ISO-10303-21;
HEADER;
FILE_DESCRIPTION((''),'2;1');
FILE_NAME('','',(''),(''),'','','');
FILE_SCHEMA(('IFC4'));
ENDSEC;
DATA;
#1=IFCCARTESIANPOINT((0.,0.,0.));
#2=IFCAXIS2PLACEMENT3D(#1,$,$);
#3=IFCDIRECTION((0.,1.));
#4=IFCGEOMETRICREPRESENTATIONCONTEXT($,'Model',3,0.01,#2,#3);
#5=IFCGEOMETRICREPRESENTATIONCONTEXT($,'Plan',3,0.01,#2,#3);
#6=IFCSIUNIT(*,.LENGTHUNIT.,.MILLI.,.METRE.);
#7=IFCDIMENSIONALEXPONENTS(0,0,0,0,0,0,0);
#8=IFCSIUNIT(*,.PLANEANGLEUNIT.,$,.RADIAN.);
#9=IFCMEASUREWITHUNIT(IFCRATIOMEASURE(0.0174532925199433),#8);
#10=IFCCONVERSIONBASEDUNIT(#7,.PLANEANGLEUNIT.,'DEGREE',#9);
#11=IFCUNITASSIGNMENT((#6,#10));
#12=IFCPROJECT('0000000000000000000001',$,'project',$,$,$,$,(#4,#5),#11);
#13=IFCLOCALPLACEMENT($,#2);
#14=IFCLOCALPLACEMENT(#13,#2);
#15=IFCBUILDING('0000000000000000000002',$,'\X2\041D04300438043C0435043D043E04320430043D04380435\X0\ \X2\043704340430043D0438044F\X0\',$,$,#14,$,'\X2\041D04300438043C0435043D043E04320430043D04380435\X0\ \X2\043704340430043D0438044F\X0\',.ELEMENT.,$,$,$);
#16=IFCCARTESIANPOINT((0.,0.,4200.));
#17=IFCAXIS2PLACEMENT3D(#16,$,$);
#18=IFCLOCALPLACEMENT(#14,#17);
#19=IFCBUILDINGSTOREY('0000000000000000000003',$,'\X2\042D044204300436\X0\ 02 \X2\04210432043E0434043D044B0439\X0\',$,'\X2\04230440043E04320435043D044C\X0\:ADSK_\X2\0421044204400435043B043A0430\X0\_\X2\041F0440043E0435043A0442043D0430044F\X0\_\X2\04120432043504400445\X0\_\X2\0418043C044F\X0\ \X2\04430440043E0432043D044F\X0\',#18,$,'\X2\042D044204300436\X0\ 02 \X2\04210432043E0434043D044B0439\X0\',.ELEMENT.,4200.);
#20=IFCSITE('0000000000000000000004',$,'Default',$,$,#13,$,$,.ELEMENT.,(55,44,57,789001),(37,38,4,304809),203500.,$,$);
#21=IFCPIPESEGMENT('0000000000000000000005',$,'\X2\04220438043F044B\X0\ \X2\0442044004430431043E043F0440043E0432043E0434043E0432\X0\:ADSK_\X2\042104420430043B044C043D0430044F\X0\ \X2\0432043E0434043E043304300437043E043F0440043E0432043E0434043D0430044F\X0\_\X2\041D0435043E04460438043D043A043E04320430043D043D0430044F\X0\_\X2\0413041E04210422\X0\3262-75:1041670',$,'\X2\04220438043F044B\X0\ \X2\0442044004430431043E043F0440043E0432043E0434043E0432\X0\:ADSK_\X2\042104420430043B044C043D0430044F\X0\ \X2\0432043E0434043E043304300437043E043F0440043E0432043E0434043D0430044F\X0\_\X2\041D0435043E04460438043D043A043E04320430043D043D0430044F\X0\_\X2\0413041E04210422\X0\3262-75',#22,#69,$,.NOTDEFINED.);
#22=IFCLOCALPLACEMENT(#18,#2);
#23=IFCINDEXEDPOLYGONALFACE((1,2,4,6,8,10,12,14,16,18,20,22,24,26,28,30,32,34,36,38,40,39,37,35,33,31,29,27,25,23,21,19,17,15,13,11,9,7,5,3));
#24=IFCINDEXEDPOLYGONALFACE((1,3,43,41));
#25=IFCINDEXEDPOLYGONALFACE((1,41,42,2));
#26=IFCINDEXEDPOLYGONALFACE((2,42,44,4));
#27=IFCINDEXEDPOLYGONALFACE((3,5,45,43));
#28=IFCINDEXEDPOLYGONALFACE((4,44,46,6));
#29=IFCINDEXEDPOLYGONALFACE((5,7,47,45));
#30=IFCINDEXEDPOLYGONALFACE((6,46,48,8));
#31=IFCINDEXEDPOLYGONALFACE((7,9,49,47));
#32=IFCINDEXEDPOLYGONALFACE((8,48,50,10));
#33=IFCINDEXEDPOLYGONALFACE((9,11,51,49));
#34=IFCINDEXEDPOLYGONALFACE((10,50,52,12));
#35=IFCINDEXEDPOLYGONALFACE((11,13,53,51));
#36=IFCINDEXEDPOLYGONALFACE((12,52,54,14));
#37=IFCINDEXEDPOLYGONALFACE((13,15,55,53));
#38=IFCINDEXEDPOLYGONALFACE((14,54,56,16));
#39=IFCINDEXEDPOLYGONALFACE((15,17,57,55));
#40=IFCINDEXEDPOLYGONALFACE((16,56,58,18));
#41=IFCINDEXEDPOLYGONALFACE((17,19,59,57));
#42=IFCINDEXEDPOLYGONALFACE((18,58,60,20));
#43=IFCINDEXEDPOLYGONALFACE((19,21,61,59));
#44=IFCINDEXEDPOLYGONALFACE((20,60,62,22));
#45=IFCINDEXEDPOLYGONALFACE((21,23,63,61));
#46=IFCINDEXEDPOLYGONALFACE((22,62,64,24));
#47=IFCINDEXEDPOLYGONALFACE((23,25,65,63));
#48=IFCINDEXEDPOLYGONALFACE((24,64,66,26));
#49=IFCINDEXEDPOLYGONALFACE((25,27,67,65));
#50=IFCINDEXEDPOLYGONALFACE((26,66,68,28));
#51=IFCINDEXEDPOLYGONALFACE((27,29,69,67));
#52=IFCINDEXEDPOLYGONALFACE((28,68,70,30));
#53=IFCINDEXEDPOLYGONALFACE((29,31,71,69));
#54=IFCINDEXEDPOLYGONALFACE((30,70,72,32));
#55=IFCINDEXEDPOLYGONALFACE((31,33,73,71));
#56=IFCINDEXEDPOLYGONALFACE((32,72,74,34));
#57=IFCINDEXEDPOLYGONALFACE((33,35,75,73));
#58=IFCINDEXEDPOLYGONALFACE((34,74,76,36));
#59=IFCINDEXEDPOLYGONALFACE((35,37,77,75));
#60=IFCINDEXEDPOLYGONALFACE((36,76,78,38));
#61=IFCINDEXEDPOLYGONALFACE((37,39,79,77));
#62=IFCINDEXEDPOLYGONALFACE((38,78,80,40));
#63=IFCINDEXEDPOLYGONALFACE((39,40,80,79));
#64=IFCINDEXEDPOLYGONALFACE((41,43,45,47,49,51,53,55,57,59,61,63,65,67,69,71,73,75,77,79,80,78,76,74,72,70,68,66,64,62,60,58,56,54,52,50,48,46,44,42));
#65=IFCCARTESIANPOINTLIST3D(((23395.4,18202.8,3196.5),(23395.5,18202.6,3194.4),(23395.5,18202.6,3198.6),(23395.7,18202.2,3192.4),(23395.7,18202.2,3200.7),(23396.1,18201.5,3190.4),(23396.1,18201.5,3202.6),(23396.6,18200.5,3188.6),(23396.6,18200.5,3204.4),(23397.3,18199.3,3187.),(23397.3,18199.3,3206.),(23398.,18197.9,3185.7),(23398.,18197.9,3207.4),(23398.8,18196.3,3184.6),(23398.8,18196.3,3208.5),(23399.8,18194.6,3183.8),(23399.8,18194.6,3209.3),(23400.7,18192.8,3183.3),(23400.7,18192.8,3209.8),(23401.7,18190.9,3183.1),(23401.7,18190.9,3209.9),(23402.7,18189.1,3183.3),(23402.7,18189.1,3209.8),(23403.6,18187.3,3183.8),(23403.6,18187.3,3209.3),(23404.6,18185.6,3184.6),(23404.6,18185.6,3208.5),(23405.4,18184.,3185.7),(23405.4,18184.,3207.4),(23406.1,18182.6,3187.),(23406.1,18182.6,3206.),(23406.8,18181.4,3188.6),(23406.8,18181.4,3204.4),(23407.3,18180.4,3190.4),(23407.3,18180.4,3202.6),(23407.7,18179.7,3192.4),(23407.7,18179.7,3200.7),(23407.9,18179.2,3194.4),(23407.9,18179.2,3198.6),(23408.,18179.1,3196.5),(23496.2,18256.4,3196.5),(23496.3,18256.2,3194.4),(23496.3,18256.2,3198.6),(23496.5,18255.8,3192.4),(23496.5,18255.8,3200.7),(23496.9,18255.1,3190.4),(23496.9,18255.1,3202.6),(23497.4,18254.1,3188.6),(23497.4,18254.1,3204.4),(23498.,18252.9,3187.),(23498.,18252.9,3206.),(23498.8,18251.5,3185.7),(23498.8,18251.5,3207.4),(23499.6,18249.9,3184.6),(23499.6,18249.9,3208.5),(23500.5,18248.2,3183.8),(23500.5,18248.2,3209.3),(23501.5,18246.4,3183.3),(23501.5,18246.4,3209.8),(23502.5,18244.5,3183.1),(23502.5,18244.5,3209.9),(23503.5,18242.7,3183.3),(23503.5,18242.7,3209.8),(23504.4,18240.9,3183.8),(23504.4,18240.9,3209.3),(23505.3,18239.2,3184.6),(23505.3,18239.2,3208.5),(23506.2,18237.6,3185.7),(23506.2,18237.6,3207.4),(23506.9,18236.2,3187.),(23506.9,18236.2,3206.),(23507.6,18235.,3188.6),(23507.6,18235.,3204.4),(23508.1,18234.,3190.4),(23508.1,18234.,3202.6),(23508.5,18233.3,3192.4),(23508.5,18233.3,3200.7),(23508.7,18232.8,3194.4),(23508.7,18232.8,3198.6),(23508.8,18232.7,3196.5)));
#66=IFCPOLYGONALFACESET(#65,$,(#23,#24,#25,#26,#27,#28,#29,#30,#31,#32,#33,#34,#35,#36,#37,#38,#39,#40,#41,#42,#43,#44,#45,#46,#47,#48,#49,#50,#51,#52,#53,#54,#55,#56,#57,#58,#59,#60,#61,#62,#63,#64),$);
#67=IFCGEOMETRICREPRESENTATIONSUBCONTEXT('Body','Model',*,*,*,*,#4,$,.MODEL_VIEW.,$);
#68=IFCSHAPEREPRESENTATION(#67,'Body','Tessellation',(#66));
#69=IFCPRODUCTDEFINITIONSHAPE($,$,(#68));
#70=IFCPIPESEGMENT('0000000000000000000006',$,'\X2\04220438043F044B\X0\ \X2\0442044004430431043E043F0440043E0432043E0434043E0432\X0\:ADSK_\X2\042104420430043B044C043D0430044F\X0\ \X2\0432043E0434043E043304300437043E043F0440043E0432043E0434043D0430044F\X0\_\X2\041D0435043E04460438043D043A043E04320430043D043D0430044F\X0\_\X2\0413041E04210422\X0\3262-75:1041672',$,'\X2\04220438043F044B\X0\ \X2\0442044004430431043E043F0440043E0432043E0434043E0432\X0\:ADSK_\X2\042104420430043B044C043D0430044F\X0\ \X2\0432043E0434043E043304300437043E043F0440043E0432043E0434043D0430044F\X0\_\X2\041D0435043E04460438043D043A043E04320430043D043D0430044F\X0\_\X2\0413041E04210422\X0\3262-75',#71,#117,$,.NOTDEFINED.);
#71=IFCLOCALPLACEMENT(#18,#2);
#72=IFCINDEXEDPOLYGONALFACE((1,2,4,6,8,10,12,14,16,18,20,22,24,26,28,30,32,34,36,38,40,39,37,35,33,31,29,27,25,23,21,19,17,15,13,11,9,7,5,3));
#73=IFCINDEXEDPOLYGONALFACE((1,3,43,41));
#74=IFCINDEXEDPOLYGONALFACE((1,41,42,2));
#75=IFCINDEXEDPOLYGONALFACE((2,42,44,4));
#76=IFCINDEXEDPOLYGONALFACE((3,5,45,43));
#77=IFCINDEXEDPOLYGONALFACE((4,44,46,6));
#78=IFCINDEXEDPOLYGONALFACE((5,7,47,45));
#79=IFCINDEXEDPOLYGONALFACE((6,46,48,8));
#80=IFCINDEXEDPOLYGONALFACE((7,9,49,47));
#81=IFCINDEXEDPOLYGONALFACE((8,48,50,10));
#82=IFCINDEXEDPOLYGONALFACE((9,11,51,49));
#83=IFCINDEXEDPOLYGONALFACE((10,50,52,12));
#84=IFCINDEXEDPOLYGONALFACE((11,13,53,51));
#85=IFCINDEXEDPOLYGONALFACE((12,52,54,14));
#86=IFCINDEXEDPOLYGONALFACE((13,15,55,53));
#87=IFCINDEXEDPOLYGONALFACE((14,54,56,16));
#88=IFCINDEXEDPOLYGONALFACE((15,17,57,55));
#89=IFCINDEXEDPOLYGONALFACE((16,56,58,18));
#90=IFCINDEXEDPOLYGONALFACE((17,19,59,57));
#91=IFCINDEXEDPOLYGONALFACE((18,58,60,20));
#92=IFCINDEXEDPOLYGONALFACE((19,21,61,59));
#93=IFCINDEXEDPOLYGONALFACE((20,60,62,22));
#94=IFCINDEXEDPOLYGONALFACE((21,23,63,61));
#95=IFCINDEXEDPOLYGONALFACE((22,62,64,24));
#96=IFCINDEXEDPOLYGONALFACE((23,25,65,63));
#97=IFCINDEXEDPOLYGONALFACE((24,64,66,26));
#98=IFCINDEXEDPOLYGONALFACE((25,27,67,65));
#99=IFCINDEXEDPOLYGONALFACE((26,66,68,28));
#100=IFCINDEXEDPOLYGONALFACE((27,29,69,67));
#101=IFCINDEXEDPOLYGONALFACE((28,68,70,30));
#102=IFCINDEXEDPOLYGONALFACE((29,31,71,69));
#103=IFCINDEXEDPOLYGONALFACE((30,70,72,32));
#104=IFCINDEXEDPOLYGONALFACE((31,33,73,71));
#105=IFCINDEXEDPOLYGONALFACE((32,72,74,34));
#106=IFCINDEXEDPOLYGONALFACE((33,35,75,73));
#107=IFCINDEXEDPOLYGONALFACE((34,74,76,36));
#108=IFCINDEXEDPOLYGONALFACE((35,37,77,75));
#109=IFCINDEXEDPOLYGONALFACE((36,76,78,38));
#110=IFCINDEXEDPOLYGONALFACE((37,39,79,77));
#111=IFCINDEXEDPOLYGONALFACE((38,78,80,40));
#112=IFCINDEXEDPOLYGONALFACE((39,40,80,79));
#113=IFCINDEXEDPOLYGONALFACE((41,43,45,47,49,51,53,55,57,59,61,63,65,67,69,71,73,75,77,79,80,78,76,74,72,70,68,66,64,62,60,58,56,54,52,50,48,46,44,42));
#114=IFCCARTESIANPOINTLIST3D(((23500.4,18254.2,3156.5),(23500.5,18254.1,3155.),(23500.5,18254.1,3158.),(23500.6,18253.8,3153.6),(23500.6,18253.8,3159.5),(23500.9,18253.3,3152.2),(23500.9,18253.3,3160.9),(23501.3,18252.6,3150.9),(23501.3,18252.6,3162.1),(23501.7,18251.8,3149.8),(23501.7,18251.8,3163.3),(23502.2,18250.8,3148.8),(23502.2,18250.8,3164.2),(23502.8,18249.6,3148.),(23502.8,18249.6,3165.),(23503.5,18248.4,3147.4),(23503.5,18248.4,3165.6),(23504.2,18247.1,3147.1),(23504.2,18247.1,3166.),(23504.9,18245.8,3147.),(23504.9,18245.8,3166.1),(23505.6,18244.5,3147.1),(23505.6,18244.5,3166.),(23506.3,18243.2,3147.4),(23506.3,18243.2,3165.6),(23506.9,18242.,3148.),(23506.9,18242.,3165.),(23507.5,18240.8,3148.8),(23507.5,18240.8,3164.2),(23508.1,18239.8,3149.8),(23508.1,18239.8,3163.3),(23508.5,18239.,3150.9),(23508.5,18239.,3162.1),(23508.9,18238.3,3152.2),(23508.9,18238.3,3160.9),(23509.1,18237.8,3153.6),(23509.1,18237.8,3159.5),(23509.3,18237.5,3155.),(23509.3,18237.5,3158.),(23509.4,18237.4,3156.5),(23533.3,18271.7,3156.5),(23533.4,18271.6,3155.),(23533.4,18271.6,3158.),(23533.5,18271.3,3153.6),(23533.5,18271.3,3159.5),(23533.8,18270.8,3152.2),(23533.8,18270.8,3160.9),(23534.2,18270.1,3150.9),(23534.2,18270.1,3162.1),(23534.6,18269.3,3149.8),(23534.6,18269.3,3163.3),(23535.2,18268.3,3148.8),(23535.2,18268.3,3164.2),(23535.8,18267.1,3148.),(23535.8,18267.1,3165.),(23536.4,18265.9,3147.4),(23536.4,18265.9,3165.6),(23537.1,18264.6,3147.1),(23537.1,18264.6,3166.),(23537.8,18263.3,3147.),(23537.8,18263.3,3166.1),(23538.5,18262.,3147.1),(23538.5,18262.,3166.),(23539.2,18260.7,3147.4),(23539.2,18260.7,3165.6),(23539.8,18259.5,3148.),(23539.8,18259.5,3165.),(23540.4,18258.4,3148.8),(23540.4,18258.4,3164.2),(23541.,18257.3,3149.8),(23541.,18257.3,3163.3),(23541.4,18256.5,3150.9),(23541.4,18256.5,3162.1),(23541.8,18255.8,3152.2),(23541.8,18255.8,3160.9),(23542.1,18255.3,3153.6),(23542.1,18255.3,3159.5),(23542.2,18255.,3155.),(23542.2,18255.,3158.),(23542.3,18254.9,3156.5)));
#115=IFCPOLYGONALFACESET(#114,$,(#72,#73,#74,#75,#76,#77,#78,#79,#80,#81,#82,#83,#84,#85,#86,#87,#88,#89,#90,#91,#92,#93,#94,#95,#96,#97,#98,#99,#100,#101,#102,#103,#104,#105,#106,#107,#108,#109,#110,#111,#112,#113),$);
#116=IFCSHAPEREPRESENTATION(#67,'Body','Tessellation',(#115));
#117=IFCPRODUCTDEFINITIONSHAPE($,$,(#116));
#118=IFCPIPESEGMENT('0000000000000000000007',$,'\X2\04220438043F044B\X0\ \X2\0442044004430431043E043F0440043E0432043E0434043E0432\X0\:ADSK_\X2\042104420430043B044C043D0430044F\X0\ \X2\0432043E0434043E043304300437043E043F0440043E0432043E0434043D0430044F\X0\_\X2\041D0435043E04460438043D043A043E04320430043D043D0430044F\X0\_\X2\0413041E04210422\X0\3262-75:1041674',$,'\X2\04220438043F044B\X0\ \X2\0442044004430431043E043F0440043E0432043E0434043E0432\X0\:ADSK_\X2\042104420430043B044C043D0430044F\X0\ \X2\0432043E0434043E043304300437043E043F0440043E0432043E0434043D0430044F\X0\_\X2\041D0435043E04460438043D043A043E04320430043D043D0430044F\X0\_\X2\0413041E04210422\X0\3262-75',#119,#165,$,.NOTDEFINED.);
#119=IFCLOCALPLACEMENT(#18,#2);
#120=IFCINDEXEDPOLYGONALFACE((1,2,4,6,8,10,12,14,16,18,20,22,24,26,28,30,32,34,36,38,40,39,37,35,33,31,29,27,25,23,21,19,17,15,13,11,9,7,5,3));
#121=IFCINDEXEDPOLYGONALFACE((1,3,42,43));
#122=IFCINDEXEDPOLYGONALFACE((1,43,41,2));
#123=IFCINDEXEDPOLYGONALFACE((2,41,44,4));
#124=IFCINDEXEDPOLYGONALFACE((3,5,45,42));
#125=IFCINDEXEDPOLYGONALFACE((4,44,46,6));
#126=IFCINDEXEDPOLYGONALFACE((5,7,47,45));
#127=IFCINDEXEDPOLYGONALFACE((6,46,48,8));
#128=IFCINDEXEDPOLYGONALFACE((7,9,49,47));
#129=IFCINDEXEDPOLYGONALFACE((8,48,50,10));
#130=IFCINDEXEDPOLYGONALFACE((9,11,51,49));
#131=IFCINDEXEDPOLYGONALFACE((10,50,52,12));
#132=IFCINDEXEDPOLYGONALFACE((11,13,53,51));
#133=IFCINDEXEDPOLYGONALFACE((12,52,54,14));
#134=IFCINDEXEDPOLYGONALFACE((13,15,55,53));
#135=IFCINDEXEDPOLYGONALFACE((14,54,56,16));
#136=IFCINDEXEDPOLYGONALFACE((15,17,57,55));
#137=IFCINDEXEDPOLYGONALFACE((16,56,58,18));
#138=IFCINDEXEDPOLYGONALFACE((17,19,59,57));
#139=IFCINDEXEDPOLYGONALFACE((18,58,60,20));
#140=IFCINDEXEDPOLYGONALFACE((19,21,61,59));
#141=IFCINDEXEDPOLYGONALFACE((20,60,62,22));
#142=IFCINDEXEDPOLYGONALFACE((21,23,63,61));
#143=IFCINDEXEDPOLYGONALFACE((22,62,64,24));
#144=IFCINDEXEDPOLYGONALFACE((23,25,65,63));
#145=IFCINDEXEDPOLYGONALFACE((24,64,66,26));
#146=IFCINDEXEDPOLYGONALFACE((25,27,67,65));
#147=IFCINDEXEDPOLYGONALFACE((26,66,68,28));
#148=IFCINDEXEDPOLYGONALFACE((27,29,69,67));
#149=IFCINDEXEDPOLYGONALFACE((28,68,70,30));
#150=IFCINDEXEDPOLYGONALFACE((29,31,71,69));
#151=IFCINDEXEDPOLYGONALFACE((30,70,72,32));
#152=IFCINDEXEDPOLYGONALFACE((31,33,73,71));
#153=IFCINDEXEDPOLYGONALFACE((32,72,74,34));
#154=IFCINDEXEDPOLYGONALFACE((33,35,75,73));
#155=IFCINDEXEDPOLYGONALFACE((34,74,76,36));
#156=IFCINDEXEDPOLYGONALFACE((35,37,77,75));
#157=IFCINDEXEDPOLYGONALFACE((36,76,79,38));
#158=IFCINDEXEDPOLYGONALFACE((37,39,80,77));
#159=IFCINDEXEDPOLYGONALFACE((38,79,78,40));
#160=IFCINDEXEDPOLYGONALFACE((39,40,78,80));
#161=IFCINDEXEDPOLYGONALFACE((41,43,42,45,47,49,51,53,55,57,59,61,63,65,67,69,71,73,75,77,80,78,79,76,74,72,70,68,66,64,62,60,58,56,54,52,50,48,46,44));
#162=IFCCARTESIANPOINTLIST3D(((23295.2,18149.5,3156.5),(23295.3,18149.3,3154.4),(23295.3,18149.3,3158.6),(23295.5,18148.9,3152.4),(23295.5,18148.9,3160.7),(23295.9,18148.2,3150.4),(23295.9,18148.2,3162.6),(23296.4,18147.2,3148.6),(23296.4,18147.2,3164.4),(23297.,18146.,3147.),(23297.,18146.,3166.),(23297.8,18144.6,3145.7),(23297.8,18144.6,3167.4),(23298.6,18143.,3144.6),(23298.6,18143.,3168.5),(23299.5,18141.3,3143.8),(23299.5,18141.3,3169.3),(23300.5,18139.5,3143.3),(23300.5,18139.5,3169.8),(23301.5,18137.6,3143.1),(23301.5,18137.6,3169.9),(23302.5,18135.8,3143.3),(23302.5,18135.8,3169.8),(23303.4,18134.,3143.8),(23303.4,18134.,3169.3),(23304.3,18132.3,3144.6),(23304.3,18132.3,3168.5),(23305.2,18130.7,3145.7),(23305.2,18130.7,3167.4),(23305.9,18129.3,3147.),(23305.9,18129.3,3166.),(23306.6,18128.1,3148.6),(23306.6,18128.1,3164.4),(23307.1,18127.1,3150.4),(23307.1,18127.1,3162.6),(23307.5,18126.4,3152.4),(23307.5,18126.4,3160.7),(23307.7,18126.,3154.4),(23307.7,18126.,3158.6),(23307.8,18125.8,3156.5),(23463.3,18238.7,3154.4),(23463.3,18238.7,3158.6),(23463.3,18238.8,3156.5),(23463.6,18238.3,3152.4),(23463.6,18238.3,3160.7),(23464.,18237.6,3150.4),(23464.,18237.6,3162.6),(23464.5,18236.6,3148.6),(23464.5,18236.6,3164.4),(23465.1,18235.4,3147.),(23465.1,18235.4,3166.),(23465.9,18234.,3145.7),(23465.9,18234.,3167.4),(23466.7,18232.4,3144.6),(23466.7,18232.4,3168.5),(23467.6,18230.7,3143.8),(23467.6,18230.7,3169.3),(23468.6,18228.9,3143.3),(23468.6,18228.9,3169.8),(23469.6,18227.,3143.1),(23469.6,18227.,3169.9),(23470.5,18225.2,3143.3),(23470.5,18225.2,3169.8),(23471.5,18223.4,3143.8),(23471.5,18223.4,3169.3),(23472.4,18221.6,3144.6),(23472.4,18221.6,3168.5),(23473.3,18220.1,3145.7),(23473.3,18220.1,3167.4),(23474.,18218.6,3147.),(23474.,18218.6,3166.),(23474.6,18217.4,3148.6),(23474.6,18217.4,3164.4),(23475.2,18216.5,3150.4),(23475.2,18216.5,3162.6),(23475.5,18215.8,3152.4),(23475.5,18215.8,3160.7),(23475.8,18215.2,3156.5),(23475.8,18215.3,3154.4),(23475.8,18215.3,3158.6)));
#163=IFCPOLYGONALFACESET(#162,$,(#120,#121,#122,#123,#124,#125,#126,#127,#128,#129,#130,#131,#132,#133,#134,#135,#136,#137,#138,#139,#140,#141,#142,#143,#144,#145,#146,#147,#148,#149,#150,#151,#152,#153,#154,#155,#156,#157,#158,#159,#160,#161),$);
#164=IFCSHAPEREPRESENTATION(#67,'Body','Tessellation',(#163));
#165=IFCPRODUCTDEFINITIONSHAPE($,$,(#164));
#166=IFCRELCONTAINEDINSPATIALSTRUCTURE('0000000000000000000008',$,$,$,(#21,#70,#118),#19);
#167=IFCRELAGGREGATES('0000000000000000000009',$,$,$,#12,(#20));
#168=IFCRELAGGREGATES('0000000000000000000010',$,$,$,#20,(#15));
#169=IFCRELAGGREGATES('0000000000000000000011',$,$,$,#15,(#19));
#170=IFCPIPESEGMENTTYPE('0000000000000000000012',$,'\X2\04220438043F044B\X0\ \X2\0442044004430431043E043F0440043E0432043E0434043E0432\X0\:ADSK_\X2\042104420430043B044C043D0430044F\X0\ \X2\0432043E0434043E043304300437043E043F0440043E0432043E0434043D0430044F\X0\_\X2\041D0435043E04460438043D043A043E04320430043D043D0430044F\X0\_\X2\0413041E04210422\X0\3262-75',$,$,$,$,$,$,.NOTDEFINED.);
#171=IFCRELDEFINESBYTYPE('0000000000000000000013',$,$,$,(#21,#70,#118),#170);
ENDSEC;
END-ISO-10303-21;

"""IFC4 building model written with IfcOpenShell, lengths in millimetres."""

from ifc_helpers import new_model, entity, si_unit, converted_unit, direction, frame, origin, place, context, subcontext, project, spatial, indexed_curve, outline, extrude, type_object, element, save


model = new_model("IFC4")

# Units and contexts
model_context = context("Model", 3, precision=0.01, world=origin(), true_north=direction((0.0, 1.0)))
plan_context = context("Plan", 3, precision=0.01, world=origin(), true_north=direction((0.0, 1.0)))
body_context = subcontext(model_context, "Body", "Model", "MODEL_VIEW")
ifc_project = project(units=[si_unit("LENGTHUNIT", "METRE", prefix="MILLI"), converted_unit("PLANEANGLEUNIT", "DEGREE", entity("IfcRatioMeasure", 0.0174532925199433), si_unit("PLANEANGLEUNIT", "RADIAN"), dimensions=[0, 0, 0, 0, 0, 0, 0])], contexts=[model_context, plan_context])

# Site, building, storey
site_placement = place(None, origin())
site = spatial("IfcSite", under=ifc_project, at=site_placement, Name="Default", CompositionType="ELEMENT", RefLatitude=(55, 44, 57, 789001), RefLongitude=(37, 38, 4, 304809), RefElevation=203500.0)
building_placement = place(site_placement, origin())
building = spatial("IfcBuilding", under=site, at=building_placement, Name="Наименование здания", LongName="Наименование здания", CompositionType="ELEMENT")
storey_placement = place(building_placement, frame((0.0, 0.0, 4200.0)))
storey = spatial("IfcBuildingStorey", under=building, at=storey_placement, Name="Этаж 02 Сводный", ObjectType="Уровень:ADSK_Стрелка_Проектная_Вверх_Имя уровня", LongName="Этаж 02 Сводный", CompositionType="ELEMENT", Elevation=4200.0)

# Pipe segments
pipe_segment_type = type_object("IfcPipeSegmentType", Name="Типы трубопроводов:ADSK_Стальная водогазопроводная_Неоцинкованная_ГОСТ3262-75", PredefinedType="NOTDEFINED")
placement = place(storey_placement, origin())
element("IfcPipeSegment", 1, at=placement, inside=storey, type_object=pipe_segment_type, Name="Типы трубопроводов:ADSK_Стальная водогазопроводная_Неоцинкованная_ГОСТ3262-75:1041670", ObjectType="Типы трубопроводов:ADSK_Стальная водогазопроводная_Неоцинкованная_ГОСТ3262-75", PredefinedType="NOTDEFINED", context=body_context, shape_type="SweptSolid", body=[
    extrude(outline(indexed_curve([(13.4, 0.0), (13.2, 2.1), (12.7, 4.1), (11.9, 6.1), (10.8, 7.9), (9.5, 9.5), (7.9, 10.8), (6.1, 11.9), (4.1, 12.7), (2.1, 13.2), (0.0, 13.4), (-2.1, 13.2), (-4.1, 12.7), (-6.1, 11.9), (-7.9, 10.8), (-9.5, 9.5), (-10.8, 7.9), (-11.9, 6.1), (-12.7, 4.1), (-13.2, 2.1), (-13.4, 0.0), (-13.2, -2.1), (-12.7, -4.1), (-11.9, -6.1), (-10.8, -7.9), (-9.5, -9.5), (-7.9, -10.8), (-6.1, -11.9), (-4.1, -12.7), (-2.1, -13.2), (0.0, -13.4), (2.1, -13.2), (4.1, -12.7), (6.1, -11.9), (7.9, -10.8), (9.5, -9.5), (10.8, -7.9), (11.9, -6.1), (12.7, -4.1), (13.2, -2.1), (13.4, 0.0)], self_intersect=False)), frame((23401.7, 18190.9, 3196.5), z_axis=(0.882948, 0.469472, 0.0), x_axis=(-0.469472, 0.882948, 0.0)), (0.0, 0.0, 1.0), 114.2),
])
element("IfcPipeSegment", 2, at=placement, inside=storey, type_object=pipe_segment_type, Name="Типы трубопроводов:ADSK_Стальная водогазопроводная_Неоцинкованная_ГОСТ3262-75:1041672", ObjectType="Типы трубопроводов:ADSK_Стальная водогазопроводная_Неоцинкованная_ГОСТ3262-75", PredefinedType="NOTDEFINED", context=body_context, shape_type="SweptSolid", body=[
    extrude(outline(indexed_curve([(9.6, 0.0), (9.4, 1.5), (9.1, 3.0), (8.5, 4.3), (7.7, 5.6), (6.8, 6.8), (5.6, 7.7), (4.3, 8.5), (3.0, 9.1), (1.5, 9.4), (0.0, 9.6), (-1.5, 9.4), (-3.0, 9.1), (-4.3, 8.5), (-5.6, 7.7), (-6.8, 6.8), (-7.7, 5.6), (-8.5, 4.3), (-9.1, 3.0), (-9.4, 1.5), (-9.6, 0.0), (-9.4, -1.5), (-9.1, -3.0), (-8.5, -4.3), (-7.7, -5.6), (-6.8, -6.8), (-5.6, -7.7), (-4.3, -8.5), (-3.0, -9.1), (-1.5, -9.4), (0.0, -9.6), (1.5, -9.4), (3.0, -9.1), (4.3, -8.5), (5.6, -7.7), (6.8, -6.8), (7.7, -5.6), (8.5, -4.3), (9.1, -3.0), (9.4, -1.5), (9.6, 0.0)], self_intersect=False)), frame((23504.9, 18245.8, 3156.5), z_axis=(0.882948, 0.469472, 0.0), x_axis=(-0.469472, 0.882948, 0.0)), (0.0, 0.0, 1.0), 37.3),
])
element("IfcPipeSegment", 3, at=placement, inside=storey, type_object=pipe_segment_type, Name="Типы трубопроводов:ADSK_Стальная водогазопроводная_Неоцинкованная_ГОСТ3262-75:1041674", ObjectType="Типы трубопроводов:ADSK_Стальная водогазопроводная_Неоцинкованная_ГОСТ3262-75", PredefinedType="NOTDEFINED", context=body_context, shape_type="SweptSolid", body=[
    extrude(outline(indexed_curve([(13.4, 0.0), (13.2, 2.1), (12.7, 4.1), (11.9, 6.1), (10.8, 7.9), (9.5, 9.5), (7.9, 10.8), (6.1, 11.9), (4.1, 12.7), (2.1, 13.2), (0.0, 13.4), (-2.1, 13.2), (-4.1, 12.7), (-6.1, 11.9), (-7.9, 10.8), (-9.5, 9.5), (-10.8, 7.9), (-11.9, 6.1), (-12.7, 4.1), (-13.2, 2.1), (-13.4, 0.0), (-13.2, -2.1), (-12.7, -4.1), (-11.9, -6.1), (-10.8, -7.9), (-9.5, -9.5), (-7.9, -10.8), (-6.1, -11.9), (-4.1, -12.7), (-2.1, -13.2), (0.0, -13.4), (2.1, -13.2), (4.1, -12.7), (6.1, -11.9), (7.9, -10.8), (9.5, -9.5), (10.8, -7.9), (11.9, -6.1), (12.7, -4.1), (13.2, -2.1), (13.4, 0.0)], self_intersect=False)), frame((23301.5, 18137.6, 3156.5), z_axis=(0.882948, 0.469472, 0.0), x_axis=(0.469472, -0.882948, 0.0)), (0.0, 0.0, 1.0), 190.4),
])

save(model, "model.ifc")
